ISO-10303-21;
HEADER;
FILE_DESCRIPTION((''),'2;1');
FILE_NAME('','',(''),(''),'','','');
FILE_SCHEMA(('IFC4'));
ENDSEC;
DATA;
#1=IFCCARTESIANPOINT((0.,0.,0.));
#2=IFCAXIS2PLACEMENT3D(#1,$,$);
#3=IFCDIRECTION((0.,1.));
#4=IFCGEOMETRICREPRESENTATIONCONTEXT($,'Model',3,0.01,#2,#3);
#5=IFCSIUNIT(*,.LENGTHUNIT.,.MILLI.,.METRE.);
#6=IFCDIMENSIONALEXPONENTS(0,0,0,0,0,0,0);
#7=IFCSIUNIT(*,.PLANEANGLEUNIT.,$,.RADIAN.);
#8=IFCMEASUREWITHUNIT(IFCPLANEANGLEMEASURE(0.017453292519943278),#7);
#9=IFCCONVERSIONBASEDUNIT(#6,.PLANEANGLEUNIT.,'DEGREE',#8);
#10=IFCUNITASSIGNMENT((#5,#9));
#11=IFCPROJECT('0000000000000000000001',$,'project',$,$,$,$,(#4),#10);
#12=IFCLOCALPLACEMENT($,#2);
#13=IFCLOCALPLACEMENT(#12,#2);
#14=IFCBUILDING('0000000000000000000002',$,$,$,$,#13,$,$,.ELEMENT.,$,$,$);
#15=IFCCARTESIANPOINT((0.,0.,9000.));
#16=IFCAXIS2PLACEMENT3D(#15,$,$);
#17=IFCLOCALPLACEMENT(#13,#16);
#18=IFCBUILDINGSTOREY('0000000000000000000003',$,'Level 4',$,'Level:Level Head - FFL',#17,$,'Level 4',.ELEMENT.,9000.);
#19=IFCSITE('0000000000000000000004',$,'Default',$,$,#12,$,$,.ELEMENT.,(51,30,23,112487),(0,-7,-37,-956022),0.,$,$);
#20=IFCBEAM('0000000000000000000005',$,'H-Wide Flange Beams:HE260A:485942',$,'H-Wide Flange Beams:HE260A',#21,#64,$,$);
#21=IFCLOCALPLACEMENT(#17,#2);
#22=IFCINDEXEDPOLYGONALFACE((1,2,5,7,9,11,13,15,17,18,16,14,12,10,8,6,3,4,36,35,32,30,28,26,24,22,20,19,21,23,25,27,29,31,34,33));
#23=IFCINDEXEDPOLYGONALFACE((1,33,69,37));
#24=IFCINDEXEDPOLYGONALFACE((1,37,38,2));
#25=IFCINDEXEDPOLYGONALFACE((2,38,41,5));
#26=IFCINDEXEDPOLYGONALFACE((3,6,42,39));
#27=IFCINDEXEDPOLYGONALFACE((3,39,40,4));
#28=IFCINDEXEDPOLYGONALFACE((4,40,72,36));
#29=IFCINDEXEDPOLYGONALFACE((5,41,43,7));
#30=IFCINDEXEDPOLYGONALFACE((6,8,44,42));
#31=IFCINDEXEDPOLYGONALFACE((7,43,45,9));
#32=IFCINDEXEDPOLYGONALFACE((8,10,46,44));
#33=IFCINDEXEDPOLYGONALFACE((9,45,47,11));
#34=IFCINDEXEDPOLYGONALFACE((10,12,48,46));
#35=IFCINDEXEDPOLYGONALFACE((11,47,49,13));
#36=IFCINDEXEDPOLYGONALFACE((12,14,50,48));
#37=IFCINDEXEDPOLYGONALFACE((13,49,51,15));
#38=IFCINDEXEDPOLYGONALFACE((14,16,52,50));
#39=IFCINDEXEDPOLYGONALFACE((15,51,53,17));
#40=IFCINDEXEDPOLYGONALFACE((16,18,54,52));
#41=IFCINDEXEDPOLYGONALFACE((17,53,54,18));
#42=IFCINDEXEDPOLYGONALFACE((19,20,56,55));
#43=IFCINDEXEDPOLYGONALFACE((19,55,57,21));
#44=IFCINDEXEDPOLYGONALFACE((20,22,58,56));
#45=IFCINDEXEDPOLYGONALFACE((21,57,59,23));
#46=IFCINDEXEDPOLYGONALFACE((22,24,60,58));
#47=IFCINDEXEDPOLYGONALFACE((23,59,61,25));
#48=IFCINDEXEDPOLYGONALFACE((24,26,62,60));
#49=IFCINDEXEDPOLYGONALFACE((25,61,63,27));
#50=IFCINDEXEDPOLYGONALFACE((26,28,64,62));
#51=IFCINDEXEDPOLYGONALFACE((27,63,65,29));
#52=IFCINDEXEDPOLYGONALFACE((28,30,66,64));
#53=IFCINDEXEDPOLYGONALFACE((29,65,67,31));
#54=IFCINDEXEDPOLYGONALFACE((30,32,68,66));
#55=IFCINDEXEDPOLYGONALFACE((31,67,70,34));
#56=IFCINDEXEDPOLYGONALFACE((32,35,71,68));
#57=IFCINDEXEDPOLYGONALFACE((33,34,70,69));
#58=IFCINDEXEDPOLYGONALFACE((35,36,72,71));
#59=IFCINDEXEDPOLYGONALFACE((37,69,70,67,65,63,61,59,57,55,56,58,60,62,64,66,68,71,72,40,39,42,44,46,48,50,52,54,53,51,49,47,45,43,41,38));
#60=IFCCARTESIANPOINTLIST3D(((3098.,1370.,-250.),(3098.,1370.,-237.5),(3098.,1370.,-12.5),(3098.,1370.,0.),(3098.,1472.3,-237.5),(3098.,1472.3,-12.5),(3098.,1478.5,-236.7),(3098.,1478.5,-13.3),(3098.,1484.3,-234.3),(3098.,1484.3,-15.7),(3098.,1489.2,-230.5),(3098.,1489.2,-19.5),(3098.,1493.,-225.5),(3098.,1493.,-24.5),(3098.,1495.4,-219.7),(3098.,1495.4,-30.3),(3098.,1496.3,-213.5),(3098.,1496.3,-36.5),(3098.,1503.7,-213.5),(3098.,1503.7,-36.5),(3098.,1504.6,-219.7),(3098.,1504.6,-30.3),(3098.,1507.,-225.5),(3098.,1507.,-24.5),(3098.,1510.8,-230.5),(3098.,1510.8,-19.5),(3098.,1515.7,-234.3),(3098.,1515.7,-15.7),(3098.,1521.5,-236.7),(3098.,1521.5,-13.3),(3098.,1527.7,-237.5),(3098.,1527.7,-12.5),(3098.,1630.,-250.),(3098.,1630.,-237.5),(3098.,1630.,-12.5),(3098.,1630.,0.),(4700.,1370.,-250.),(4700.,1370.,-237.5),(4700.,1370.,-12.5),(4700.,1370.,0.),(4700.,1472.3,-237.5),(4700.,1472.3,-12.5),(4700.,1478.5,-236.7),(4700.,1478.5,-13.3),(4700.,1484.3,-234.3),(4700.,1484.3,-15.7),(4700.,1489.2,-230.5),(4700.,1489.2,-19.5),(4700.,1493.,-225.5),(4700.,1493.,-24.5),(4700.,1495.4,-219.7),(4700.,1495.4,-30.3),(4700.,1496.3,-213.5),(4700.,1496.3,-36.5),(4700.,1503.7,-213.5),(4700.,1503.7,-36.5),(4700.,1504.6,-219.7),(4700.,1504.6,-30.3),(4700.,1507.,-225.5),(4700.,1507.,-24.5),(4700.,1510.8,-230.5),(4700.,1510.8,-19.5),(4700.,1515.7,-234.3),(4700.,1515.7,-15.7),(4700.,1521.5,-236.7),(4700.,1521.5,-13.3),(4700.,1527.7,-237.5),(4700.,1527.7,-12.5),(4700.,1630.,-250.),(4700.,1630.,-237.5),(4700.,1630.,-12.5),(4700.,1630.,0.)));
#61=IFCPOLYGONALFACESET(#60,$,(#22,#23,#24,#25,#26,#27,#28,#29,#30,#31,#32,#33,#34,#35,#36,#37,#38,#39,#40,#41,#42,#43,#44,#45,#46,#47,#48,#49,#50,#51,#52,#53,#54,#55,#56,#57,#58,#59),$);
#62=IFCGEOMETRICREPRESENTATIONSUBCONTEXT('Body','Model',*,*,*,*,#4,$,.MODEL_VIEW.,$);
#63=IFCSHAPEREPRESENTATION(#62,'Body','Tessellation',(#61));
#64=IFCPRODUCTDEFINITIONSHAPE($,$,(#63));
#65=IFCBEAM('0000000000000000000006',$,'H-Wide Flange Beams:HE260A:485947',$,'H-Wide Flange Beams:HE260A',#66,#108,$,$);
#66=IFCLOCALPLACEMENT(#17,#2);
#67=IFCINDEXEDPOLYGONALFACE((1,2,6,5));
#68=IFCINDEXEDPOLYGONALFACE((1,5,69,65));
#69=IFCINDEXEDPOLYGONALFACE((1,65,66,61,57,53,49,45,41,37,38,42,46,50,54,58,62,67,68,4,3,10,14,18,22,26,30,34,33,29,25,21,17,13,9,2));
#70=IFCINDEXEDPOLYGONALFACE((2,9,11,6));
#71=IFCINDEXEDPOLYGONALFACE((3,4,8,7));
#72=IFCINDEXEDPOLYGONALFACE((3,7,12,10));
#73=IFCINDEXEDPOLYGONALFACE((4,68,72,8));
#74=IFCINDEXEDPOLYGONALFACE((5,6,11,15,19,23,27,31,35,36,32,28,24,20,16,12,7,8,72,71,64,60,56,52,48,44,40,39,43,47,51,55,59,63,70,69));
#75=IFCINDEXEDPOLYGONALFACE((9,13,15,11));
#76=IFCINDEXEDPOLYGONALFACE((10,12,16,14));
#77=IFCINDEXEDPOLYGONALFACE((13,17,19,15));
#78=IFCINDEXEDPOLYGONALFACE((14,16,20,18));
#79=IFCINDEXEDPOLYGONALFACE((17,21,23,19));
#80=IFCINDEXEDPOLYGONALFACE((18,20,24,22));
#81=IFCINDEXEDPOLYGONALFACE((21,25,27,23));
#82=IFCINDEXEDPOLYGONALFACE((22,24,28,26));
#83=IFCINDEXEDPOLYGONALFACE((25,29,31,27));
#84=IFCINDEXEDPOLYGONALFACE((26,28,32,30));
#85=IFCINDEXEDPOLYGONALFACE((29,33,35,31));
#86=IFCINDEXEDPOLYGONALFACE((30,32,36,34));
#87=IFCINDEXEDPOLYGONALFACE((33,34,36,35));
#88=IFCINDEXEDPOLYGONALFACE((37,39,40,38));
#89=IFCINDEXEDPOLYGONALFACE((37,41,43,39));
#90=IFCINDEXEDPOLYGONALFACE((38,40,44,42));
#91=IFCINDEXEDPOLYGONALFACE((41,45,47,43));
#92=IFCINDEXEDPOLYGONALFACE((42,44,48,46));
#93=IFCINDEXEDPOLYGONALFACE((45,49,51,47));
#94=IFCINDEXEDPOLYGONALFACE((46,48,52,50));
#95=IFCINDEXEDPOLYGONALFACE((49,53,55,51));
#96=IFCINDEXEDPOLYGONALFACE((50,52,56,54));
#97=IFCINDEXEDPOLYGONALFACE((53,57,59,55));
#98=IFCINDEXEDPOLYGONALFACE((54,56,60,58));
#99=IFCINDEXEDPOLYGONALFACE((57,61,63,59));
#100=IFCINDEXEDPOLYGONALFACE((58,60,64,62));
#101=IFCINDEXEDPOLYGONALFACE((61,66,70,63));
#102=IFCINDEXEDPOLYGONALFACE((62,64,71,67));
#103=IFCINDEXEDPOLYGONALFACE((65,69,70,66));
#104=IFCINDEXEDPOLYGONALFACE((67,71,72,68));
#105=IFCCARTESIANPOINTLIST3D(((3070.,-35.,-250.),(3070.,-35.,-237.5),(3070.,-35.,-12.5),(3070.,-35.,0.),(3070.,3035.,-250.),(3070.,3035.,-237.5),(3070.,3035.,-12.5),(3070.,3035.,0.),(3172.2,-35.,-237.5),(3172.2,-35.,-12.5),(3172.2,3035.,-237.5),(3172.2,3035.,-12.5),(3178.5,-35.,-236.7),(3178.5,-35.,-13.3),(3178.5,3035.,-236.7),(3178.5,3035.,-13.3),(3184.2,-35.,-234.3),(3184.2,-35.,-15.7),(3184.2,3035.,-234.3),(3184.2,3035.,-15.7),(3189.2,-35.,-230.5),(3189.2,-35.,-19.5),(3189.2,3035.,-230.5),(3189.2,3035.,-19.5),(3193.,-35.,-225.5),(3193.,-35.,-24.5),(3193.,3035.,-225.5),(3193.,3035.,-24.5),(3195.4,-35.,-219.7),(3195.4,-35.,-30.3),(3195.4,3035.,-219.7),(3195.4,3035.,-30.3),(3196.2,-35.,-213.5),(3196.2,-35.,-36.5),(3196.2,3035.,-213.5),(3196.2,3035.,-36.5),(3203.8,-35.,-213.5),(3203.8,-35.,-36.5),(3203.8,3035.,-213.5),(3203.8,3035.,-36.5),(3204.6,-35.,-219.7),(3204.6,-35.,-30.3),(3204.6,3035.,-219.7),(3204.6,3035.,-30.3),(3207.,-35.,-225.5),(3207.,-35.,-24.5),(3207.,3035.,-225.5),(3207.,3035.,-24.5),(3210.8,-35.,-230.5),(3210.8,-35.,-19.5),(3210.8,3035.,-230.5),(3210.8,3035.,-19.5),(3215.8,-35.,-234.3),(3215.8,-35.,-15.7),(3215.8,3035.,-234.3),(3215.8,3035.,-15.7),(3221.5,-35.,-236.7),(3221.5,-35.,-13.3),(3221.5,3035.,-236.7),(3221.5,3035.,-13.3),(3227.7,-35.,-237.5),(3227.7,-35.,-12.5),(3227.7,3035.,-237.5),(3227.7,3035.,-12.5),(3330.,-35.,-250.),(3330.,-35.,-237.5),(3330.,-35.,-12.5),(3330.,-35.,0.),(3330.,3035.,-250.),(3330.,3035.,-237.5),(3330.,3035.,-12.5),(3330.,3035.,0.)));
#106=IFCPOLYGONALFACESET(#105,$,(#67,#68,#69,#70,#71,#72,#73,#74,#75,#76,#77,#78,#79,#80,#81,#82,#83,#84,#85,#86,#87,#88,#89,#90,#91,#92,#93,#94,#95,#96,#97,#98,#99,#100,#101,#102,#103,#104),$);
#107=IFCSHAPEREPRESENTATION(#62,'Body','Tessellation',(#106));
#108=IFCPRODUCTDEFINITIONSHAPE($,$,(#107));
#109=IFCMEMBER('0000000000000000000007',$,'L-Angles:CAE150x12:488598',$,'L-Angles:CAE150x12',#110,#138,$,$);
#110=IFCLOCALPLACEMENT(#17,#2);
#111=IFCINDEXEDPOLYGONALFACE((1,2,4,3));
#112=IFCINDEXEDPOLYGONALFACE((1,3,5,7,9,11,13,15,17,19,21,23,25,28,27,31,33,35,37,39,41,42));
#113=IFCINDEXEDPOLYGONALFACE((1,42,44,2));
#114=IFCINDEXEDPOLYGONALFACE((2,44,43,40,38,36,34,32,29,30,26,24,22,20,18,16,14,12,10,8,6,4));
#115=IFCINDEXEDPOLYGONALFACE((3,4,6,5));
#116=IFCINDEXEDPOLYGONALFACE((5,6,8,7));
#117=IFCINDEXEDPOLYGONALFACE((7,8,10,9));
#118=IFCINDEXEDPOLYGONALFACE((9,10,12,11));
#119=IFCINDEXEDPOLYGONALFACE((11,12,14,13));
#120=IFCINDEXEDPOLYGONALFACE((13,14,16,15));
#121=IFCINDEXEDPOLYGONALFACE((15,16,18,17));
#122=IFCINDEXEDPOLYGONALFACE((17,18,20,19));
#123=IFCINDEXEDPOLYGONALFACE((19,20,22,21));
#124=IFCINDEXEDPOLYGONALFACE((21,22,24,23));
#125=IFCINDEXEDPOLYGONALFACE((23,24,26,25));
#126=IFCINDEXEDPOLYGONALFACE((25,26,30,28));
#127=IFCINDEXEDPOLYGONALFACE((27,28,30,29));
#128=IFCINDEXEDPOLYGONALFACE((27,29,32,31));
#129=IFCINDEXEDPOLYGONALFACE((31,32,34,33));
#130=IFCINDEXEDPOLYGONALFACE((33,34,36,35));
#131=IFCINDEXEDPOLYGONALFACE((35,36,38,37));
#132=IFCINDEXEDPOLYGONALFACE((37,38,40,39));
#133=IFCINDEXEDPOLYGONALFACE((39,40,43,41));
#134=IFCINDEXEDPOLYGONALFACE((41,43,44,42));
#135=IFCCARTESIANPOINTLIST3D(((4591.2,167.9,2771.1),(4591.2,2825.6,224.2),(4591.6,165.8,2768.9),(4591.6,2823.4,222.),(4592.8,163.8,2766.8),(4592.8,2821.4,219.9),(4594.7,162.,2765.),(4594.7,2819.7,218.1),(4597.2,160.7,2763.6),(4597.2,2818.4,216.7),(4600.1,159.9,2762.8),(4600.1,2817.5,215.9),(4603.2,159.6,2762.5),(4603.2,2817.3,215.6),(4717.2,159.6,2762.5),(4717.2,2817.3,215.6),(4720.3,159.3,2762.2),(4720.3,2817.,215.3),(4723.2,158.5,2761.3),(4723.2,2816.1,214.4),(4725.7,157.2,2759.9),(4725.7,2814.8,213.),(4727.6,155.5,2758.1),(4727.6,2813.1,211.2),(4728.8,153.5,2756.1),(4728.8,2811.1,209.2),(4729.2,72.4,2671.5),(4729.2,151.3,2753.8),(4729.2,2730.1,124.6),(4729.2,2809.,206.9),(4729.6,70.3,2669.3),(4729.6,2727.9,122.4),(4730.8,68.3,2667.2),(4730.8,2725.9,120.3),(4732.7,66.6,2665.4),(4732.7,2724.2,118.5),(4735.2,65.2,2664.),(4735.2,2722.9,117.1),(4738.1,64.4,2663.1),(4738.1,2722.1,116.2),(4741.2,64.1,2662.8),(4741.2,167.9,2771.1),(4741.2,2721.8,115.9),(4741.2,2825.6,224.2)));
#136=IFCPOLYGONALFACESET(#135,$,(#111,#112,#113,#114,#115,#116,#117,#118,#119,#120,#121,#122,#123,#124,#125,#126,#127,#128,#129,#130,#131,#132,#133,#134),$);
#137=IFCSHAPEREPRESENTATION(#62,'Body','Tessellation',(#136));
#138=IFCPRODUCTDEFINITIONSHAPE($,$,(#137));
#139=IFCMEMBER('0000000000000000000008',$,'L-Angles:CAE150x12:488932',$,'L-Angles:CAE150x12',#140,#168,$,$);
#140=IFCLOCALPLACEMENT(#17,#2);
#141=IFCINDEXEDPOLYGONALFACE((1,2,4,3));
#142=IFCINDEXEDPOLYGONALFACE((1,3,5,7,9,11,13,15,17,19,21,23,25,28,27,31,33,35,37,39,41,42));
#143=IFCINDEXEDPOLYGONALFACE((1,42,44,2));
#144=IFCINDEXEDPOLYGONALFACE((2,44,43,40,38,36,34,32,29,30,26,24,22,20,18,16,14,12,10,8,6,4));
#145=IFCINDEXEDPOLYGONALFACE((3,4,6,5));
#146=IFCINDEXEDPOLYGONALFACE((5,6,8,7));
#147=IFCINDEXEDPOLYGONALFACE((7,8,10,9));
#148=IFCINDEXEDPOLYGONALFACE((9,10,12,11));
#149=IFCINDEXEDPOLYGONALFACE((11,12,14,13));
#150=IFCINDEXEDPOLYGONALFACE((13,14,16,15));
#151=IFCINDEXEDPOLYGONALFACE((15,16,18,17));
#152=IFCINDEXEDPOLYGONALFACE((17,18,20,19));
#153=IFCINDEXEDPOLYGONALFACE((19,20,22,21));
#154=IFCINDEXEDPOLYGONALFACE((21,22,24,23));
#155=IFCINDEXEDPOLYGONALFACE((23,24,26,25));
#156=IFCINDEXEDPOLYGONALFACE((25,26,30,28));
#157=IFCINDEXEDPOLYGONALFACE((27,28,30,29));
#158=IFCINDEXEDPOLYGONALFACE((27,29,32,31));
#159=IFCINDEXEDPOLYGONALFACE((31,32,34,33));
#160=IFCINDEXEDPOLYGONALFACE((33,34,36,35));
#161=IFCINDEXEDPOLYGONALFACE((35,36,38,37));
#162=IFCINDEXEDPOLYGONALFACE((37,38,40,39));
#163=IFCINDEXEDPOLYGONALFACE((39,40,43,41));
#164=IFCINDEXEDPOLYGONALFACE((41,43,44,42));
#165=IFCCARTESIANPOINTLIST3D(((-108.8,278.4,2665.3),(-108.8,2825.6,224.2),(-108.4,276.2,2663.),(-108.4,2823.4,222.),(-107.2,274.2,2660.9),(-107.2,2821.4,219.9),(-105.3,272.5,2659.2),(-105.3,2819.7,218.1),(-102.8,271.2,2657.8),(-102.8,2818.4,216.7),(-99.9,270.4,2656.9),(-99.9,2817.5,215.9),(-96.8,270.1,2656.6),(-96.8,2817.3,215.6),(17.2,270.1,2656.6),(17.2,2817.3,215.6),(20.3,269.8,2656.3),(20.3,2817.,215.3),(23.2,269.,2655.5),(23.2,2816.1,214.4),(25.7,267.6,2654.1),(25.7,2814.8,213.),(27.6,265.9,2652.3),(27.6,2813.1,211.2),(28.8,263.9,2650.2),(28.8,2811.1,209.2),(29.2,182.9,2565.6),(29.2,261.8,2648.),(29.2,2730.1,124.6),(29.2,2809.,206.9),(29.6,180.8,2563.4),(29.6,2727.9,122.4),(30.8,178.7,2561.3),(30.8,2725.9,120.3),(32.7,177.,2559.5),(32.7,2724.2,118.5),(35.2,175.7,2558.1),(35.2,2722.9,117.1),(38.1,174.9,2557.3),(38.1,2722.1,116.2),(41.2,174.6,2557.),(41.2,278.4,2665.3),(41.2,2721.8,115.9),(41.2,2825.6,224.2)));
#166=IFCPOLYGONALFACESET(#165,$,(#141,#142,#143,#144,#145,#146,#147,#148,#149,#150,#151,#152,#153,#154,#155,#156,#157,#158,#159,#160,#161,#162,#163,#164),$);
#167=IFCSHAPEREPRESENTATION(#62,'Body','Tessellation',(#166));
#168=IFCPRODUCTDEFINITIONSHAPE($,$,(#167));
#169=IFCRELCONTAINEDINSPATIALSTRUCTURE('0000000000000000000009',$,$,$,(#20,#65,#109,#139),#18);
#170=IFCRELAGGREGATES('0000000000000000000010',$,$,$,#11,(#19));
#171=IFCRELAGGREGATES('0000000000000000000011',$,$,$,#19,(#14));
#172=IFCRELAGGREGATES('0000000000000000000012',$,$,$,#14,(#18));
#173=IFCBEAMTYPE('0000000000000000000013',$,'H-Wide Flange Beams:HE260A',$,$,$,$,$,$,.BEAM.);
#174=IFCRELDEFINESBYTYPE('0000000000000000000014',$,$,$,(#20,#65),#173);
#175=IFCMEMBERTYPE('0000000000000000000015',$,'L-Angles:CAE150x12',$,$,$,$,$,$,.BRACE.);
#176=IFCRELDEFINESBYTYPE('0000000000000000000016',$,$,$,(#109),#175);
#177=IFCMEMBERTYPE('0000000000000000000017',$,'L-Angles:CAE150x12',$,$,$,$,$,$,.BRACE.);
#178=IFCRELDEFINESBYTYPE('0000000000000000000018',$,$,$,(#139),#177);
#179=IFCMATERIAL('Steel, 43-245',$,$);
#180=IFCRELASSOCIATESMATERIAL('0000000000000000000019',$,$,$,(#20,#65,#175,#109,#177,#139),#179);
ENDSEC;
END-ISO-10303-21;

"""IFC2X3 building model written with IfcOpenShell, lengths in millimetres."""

from ifc_helpers import new_model, entity, si_unit, converted_unit, direction, frame, frame_2d, origin, place, context, subcontext, project, spatial, polyline, circle_curve, parameter, trimmed, segment, composite_curve, i_section, outline, extrude, source, transform, mapped, material, type_object, type_shapes, element, save


model = new_model("IFC2X3")

# Units and contexts
model_context = context("Model", 3, precision=0.01, world=origin(), true_north=direction((0.0, 1.0)))
body_context = subcontext(model_context, "Body", "Model", "MODEL_VIEW")
ifc_project = project(units=[si_unit("LENGTHUNIT", "METRE", prefix="MILLI"), converted_unit("PLANEANGLEUNIT", "DEGREE", entity("IfcPlaneAngleMeasure", 0.017453292519943278), si_unit("PLANEANGLEUNIT", "RADIAN"), dimensions=[0, 0, 0, 0, 0, 0, 0])], contexts=[model_context])

# Site, building, storey
site_placement = place(None, origin())
site = spatial("IfcSite", under=ifc_project, at=site_placement, Name="Default", CompositionType="ELEMENT", RefLatitude=(51, 30, 23, 112487), RefLongitude=(0, -7, -37, -956022), RefElevation=0.0)
building_placement = place(site_placement, origin())
building = spatial("IfcBuilding", under=site, at=building_placement, CompositionType="ELEMENT")
storey_placement = place(building_placement, frame((0.0, 0.0, 9000.0)))
storey = spatial("IfcBuildingStorey", under=building, at=storey_placement, Name="Level 4", ObjectType="Level:Level Head - FFL", LongName="Level 4", CompositionType="ELEMENT", Elevation=9000.0)

# Beams
ifc_material = material(Name="Steel, 43-245")
beam_type_1 = type_object("IfcBeamType", Name="H-Wide Flange Beams:HE260A", PredefinedType="BEAM")
beam_1_placement = place(storey_placement, frame((4700.0, 1500.0, 0.0), z_axis=(0.0, 0.0, 1.0), x_axis=(-1.0, 0.0, 0.0)))
element("IfcBeam", 1, at=beam_1_placement, inside=storey, type_object=beam_type_1, material=ifc_material, Name="H-Wide Flange Beams:HE260A:485942", ObjectType="H-Wide Flange Beams:HE260A", context=body_context, shape_type="SweptSolid", body=[
    extrude(i_section(OverallWidth=260.0, OverallDepth=250.0, WebThickness=7.5, FlangeThickness=12.5, FilletRadius=24.0, at=frame_2d((0.0, 0.0), x_axis=(0.0, 1.0))), frame((0.0, 0.0, -125.0), z_axis=(1.0, 0.0, 0.0), x_axis=(0.0, 0.0, -1.0)), (0.0, 0.0, 1.0), 1602.0),
])
beam_2_placement = place(storey_placement, frame((3200.0, 0.0, 0.0), z_axis=(0.0, 0.0, 1.0), x_axis=(0.0, 1.0, 0.0)))
element("IfcBeam", 2, at=beam_2_placement, inside=storey, type_object=beam_type_1, material=ifc_material, Name="H-Wide Flange Beams:HE260A:485947", ObjectType="H-Wide Flange Beams:HE260A", context=body_context, shape_type="SweptSolid", body=[
    extrude(i_section(OverallWidth=260.0, OverallDepth=250.0, WebThickness=7.5, FlangeThickness=12.5, FilletRadius=24.0, at=frame_2d((0.0, 0.0), x_axis=(0.0, 1.0))), frame((-35.0, 0.0, -125.0), z_axis=(1.0, 0.0, 0.0), x_axis=(0.0, 0.0, -1.0)), (0.0, 0.0, 1.0), 3070.0),
])

# Members
member_type_1 = type_object("IfcMemberType", Name="L-Angles:CAE150x12", PredefinedType="BRACE", material=ifc_material)
shared_shape_1 = source(origin(), body_context, "Body", "SweptSolid", [
    extrude(outline(composite_curve([segment(polyline([(-102.0, -48.0), (48.0, -48.0)]), True, "CONTINUOUS"), segment(polyline([(48.0, -48.0), (48.0, 102.0)]), True, "CONTINUOUS"), segment(trimmed(circle_curve(frame_2d((48.0, 90.0), x_axis=(0.0, 1.0)), 12.0), [parameter(0.0)], [parameter(90.0)], True, "PARAMETER"), True, "CONTINUOUS"), segment(polyline([(36.0, 90.0), (36.0, -24.0)]), True, "CONTINUOUS"), segment(trimmed(circle_curve(frame_2d((24.0, -24.0), x_axis=(1.0, 0.0)), 12.0), [parameter(270.0)], [parameter(0.0)], True, "PARAMETER"), False, "CONTINUOUS"), segment(polyline([(24.0, -36.0), (-90.0, -36.0)]), True, "CONTINUOUS"), segment(trimmed(circle_curve(frame_2d((-90.0, -48.0), x_axis=(0.0, 1.0)), 12.0), [parameter(0.0)], [parameter(90.0)], True, "PARAMETER"), True, "CONTINUOUS")], self_intersect=False)), frame((-1796.5, -6.8, -6.8), z_axis=(1.0, 0.0, 0.0), x_axis=(0.0, 0.0, 1.0)), (0.0, 0.0, 1.0), 3681.0),
])
type_shapes(member_type_1, [shared_shape_1])
member_1_placement = place(storey_placement, frame((4700.0, 1500.0, 1437.5), z_axis=(0.0, 0.691905, 0.721988), x_axis=(0.0, -0.721988, 0.691905)))
element("IfcMember", 3, at=member_1_placement, inside=storey, type_object=member_type_1, material=ifc_material, Name="L-Angles:CAE150x12:488598", ObjectType="L-Angles:CAE150x12", context=body_context, shape_type="MappedRepresentation", body=[
    mapped(shared_shape_1, transform((0.0, 0.0, 0.0), scale=1.0)),
])
member_type_2 = type_object("IfcMemberType", Name="L-Angles:CAE150x12", PredefinedType="BRACE", material=ifc_material)
shared_shape_2 = source(origin(), body_context, "Body", "SweptSolid", [
    extrude(outline(composite_curve([segment(polyline([(-102.0, -48.0), (48.0, -48.0)]), True, "CONTINUOUS"), segment(polyline([(48.0, -48.0), (48.0, 102.0)]), True, "CONTINUOUS"), segment(trimmed(circle_curve(frame_2d((48.0, 90.0), x_axis=(0.0, 1.0)), 12.0), [parameter(0.0)], [parameter(90.0)], True, "PARAMETER"), True, "CONTINUOUS"), segment(polyline([(36.0, 90.0), (36.0, -24.0)]), True, "CONTINUOUS"), segment(trimmed(circle_curve(frame_2d((24.0, -24.0), x_axis=(1.0, 0.0)), 12.0), [parameter(270.0)], [parameter(0.0)], True, "PARAMETER"), False, "CONTINUOUS"), segment(polyline([(24.0, -36.0), (-90.0, -36.0)]), True, "CONTINUOUS"), segment(trimmed(circle_curve(frame_2d((-90.0, -48.0), x_axis=(0.0, 1.0)), 12.0), [parameter(0.0)], [parameter(90.0)], True, "PARAMETER"), True, "CONTINUOUS")], self_intersect=False)), frame((-1796.5, -6.8, -6.8), z_axis=(1.0, 0.0, 0.0), x_axis=(0.0, 0.0, 1.0)), (0.0, 0.0, 1.0), 3528.0),
])
type_shapes(member_type_2, [shared_shape_2])
member_2_placement = place(storey_placement, frame((0.0, 1500.0, 1437.5), z_axis=(0.0, 0.691905, 0.721988), x_axis=(0.0, -0.721988, 0.691905)))
element("IfcMember", 4, at=member_2_placement, inside=storey, type_object=member_type_2, material=ifc_material, Name="L-Angles:CAE150x12:488932", ObjectType="L-Angles:CAE150x12", context=body_context, shape_type="MappedRepresentation", body=[
    mapped(shared_shape_2, transform((0.0, 0.0, 0.0), scale=1.0)),
])

save(model, "model.ifc")
